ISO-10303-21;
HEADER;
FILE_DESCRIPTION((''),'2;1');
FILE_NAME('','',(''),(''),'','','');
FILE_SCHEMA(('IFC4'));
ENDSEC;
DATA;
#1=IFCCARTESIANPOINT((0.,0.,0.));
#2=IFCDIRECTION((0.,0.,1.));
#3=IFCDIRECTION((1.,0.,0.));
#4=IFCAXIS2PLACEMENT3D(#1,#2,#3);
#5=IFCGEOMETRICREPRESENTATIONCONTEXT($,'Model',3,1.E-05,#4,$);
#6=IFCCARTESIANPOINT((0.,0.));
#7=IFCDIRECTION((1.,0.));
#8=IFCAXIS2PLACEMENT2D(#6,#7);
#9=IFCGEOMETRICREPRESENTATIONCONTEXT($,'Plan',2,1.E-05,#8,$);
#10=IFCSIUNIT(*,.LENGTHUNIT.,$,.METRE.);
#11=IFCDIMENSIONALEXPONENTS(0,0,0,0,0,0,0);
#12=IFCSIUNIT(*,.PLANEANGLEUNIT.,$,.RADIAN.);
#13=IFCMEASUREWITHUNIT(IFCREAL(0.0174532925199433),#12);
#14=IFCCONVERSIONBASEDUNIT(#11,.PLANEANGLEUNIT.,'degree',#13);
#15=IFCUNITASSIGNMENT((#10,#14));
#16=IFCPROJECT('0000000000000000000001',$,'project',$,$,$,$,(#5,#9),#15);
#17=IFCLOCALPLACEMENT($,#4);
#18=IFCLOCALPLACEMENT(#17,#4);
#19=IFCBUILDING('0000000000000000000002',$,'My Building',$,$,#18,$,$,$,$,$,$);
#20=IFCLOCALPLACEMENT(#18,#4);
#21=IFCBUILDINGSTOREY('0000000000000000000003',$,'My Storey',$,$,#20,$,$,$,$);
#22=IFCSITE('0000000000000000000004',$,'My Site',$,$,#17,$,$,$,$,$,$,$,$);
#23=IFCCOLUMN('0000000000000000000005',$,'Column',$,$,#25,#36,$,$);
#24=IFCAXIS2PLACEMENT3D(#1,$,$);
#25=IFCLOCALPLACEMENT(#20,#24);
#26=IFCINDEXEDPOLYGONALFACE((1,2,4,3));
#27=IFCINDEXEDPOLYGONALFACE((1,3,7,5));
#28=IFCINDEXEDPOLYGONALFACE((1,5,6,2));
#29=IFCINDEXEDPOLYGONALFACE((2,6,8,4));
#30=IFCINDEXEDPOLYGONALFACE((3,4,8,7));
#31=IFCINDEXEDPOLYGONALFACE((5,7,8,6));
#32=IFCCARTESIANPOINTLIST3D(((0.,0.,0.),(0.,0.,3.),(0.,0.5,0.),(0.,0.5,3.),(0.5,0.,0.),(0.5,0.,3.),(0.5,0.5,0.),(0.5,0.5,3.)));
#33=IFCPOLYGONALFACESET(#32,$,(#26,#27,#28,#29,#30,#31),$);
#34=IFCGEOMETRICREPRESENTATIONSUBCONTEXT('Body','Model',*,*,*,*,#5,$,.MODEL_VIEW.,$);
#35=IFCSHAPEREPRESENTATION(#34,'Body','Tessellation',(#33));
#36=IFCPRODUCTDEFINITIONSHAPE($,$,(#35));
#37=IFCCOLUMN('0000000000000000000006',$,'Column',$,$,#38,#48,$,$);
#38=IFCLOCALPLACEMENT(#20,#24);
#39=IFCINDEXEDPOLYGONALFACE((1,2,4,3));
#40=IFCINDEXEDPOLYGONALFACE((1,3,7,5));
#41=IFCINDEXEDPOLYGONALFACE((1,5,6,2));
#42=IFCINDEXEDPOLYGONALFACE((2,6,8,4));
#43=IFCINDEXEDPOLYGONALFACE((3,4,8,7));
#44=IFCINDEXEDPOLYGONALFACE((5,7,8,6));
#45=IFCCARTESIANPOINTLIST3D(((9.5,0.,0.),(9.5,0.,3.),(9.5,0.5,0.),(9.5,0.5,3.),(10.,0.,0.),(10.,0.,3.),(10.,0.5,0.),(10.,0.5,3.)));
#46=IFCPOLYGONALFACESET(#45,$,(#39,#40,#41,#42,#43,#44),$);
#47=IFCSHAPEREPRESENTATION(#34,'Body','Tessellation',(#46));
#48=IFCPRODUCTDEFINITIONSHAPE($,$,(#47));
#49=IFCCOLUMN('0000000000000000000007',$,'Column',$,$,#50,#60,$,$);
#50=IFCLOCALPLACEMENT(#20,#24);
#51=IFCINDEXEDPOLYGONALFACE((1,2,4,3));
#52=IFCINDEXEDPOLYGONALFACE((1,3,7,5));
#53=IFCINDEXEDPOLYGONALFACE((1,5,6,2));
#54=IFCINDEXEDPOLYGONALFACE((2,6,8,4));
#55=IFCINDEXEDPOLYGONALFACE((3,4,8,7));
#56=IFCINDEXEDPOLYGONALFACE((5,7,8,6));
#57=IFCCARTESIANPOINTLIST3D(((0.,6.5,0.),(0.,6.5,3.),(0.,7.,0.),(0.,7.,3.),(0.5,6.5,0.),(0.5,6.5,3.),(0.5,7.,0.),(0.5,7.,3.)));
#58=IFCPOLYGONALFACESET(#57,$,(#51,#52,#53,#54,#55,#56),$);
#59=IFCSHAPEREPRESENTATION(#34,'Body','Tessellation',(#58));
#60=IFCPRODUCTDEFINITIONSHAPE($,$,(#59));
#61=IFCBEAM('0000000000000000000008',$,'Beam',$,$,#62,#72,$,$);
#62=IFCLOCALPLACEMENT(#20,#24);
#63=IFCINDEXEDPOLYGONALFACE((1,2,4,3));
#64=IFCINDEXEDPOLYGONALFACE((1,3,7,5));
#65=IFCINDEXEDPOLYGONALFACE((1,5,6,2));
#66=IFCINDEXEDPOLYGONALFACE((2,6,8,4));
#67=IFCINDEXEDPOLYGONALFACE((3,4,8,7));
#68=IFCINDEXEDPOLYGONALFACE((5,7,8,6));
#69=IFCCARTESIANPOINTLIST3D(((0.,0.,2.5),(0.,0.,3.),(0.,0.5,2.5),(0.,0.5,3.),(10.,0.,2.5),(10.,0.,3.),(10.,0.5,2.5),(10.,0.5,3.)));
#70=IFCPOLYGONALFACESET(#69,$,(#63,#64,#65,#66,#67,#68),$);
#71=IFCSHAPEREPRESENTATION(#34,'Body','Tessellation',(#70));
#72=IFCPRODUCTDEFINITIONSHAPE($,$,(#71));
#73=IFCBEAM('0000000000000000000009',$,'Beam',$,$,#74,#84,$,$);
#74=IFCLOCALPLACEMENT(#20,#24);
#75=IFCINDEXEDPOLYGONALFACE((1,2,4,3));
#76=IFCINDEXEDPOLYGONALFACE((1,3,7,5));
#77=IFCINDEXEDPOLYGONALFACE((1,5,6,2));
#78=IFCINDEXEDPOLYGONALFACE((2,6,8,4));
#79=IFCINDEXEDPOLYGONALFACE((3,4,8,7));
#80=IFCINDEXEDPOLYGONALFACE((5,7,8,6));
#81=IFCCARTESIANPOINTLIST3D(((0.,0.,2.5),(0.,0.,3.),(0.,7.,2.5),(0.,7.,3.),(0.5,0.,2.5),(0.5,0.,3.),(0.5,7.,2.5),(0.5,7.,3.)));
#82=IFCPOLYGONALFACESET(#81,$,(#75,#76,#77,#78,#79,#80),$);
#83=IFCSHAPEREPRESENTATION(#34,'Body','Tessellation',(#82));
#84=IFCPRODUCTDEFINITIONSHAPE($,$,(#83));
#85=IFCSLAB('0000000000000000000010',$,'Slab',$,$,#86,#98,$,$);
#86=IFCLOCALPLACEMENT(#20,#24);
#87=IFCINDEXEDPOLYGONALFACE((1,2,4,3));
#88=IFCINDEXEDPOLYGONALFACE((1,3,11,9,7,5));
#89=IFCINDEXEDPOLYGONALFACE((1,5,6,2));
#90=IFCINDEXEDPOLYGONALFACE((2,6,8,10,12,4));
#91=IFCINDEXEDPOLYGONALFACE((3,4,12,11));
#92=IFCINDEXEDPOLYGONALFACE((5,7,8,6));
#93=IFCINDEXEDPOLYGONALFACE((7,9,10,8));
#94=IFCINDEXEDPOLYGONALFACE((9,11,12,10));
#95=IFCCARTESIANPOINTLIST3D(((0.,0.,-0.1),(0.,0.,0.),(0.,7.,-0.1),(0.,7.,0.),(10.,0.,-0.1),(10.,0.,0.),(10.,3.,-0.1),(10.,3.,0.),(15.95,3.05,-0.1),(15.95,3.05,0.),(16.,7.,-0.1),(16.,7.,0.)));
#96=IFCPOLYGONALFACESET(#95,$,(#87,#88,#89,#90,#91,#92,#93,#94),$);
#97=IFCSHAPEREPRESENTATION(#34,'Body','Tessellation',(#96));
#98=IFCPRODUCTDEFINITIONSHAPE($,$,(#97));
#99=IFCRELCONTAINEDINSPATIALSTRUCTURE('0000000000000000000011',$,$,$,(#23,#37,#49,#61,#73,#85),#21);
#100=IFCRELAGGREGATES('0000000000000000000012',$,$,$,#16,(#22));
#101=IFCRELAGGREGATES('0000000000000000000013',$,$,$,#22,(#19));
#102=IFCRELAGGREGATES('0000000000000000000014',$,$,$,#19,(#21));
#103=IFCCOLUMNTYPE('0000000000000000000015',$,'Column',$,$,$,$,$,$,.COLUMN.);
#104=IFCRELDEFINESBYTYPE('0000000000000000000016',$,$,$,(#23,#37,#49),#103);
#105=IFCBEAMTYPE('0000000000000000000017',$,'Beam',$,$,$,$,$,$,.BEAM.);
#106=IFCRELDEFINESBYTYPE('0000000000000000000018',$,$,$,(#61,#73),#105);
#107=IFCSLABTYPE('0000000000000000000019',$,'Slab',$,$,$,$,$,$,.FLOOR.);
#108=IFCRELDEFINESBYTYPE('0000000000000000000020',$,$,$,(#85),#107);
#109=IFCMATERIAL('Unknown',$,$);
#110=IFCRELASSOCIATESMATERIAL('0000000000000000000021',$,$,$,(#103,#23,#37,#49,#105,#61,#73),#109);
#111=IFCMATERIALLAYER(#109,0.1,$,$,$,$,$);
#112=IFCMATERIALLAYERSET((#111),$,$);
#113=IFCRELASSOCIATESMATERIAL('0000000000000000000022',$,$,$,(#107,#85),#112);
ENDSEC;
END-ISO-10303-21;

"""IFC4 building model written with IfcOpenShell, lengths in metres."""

from ifc_helpers import new_model, entity, si_unit, converted_unit, frame, origin_with_axes, origin_2d_with_axis, place, context, subcontext, project, spatial, indexed_curve, rectangle, outline, extrude, material, layer, layer_set, layer_usage, material_profile, profile_set, profile_usage, type_object, element, save


model = new_model("IFC4")

# Units and contexts
model_context = context("Model", 3, precision=1e-05, world=origin_with_axes())
plan_context = context("Plan", 2, precision=1e-05, world=origin_2d_with_axis())
body_context_1 = subcontext(model_context, "Body", "Model", "MODEL_VIEW")
ifc_project = project(units=[si_unit("LENGTHUNIT", "METRE"), converted_unit("PLANEANGLEUNIT", "degree", entity("IfcReal", 0.0174532925199433), si_unit("PLANEANGLEUNIT", "RADIAN"), dimensions=[0, 0, 0, 0, 0, 0, 0])], contexts=[model_context, plan_context])

# Site, building, storey
site_placement = place(None, origin_with_axes())
site = spatial("IfcSite", under=ifc_project, at=site_placement, Name="My Site")
building_placement = place(site_placement, origin_with_axes())
building = spatial("IfcBuilding", under=site, at=building_placement, Name="My Building")
storey_placement = place(building_placement, origin_with_axes())
storey = spatial("IfcBuildingStorey", under=building, at=storey_placement, Name="My Storey")

# Columns
ifc_material = material(Name="Unknown")
ifc_material_profile_1 = material_profile(ifc_material, rectangle(XDim=0.5, YDim=0.5))
ifc_profile_set_1 = profile_set([ifc_material_profile_1])
ifc_profile_usage_1 = profile_usage(ifc_profile_set_1, cardinal=5)
column_type = type_object("IfcColumnType", Name="Column", PredefinedType="COLUMN", material=ifc_profile_set_1)
column_1_placement = place(storey_placement, frame((0.25, 0.25, 0.0), z_axis=(0.0, 0.0, 1.0), x_axis=(1.0, 0.0, 0.0)))
element("IfcColumn", 1, at=column_1_placement, inside=storey, type_object=column_type, material=ifc_profile_usage_1, Name="Column", context=body_context_1, shape_type="SweptSolid", body=[
    extrude(rectangle(XDim=0.5, YDim=0.5), origin_with_axes(), (0.0, 0.0, 1.0), 3.0),
])
ifc_profile_usage_2 = profile_usage(ifc_profile_set_1, cardinal=5)
column_2_placement = place(storey_placement, frame((9.75, 0.25, 0.0), z_axis=(0.0, 0.0, 1.0), x_axis=(1.0, 0.0, 0.0)))
element("IfcColumn", 2, at=column_2_placement, inside=storey, type_object=column_type, material=ifc_profile_usage_2, Name="Column", context=body_context_1, shape_type="SweptSolid", body=[
    extrude(rectangle(XDim=0.5, YDim=0.5), origin_with_axes(), (0.0, 0.0, 1.0), 3.0),
])
ifc_profile_usage_3 = profile_usage(ifc_profile_set_1, cardinal=5)
column_3_placement = place(storey_placement, frame((0.25, 6.75, 0.0), z_axis=(0.0, 0.0, 1.0), x_axis=(1.0, 0.0, 0.0)))
element("IfcColumn", 3, at=column_3_placement, inside=storey, type_object=column_type, material=ifc_profile_usage_3, Name="Column", context=body_context_1, shape_type="SweptSolid", body=[
    extrude(rectangle(XDim=0.5, YDim=0.5), origin_with_axes(), (0.0, 0.0, 1.0), 3.0),
])

# Beams
ifc_material_profile_2 = material_profile(ifc_material, rectangle(XDim=0.5, YDim=0.5))
ifc_profile_set_2 = profile_set([ifc_material_profile_2])
ifc_profile_usage_4 = profile_usage(ifc_profile_set_2, cardinal=8)
beam_type = type_object("IfcBeamType", Name="Beam", PredefinedType="BEAM", material=ifc_profile_set_2)
beam_1_placement = place(storey_placement, frame((0.0, 0.25, 3.0), z_axis=(1.0, 0.0, 0.0), x_axis=(0.0, 1.0, 0.0)))
element("IfcBeam", 4, at=beam_1_placement, inside=storey, type_object=beam_type, material=ifc_profile_usage_4, Name="Beam", context=body_context_1, shape_type="SweptSolid", body=[
    extrude(rectangle(XDim=0.5, YDim=0.5), frame((0.0, -0.25, 0.0), z_axis=(0.0, 0.0, 1.0), x_axis=(1.0, 0.0, 0.0)), (0.0, 0.0, 1.0), 10.0),
])
ifc_profile_usage_5 = profile_usage(ifc_profile_set_2, cardinal=8)
beam_2_placement = place(storey_placement, frame((0.25, 7.0, 3.0), z_axis=(0.0, -1.0, 0.0), x_axis=(1.0, 0.0, 0.0)))
element("IfcBeam", 5, at=beam_2_placement, inside=storey, type_object=beam_type, material=ifc_profile_usage_5, Name="Beam", context=body_context_1, shape_type="SweptSolid", body=[
    extrude(rectangle(XDim=0.5, YDim=0.5), frame((0.0, -0.25, 0.0), z_axis=(0.0, 0.0, 1.0), x_axis=(1.0, 0.0, 0.0)), (0.0, 0.0, 1.0), 7.0),
])

# Slab
ifc_layer_1 = layer(ifc_material, 0.1)
ifc_layer_set_1 = layer_set([ifc_layer_1])
ifc_layer_usage_1 = layer_usage(ifc_layer_set_1, "AXIS3", "POSITIVE", -0.1)
slab_type = type_object("IfcSlabType", Name="Slab", PredefinedType="FLOOR", material=ifc_layer_set_1)
slab_placement = place(storey_placement, frame((0.0, 7.0, 0.0), z_axis=(0.0, 0.0, 1.0), x_axis=(1.0, 0.0, 0.0)))
element("IfcSlab", 6, at=slab_placement, inside=storey, type_object=slab_type, material=ifc_layer_usage_1, Name="Slab", context=body_context_1, shape_type="SweptSolid", body=[
    extrude(outline(indexed_curve([(0.0, 0.0), (0.0, -7.0), (10.0, -7.0), (10.0, -4.0), (15.95, -3.95), (16.0, 0.0), (0.0, 0.0)])), frame((0.0, 0.0, -0.1), z_axis=(0.0, 0.0, 1.0), x_axis=(1.0, 0.0, 0.0)), (0.0, 0.0, 1.0), 0.1),
])

save(model, "model.ifc")
